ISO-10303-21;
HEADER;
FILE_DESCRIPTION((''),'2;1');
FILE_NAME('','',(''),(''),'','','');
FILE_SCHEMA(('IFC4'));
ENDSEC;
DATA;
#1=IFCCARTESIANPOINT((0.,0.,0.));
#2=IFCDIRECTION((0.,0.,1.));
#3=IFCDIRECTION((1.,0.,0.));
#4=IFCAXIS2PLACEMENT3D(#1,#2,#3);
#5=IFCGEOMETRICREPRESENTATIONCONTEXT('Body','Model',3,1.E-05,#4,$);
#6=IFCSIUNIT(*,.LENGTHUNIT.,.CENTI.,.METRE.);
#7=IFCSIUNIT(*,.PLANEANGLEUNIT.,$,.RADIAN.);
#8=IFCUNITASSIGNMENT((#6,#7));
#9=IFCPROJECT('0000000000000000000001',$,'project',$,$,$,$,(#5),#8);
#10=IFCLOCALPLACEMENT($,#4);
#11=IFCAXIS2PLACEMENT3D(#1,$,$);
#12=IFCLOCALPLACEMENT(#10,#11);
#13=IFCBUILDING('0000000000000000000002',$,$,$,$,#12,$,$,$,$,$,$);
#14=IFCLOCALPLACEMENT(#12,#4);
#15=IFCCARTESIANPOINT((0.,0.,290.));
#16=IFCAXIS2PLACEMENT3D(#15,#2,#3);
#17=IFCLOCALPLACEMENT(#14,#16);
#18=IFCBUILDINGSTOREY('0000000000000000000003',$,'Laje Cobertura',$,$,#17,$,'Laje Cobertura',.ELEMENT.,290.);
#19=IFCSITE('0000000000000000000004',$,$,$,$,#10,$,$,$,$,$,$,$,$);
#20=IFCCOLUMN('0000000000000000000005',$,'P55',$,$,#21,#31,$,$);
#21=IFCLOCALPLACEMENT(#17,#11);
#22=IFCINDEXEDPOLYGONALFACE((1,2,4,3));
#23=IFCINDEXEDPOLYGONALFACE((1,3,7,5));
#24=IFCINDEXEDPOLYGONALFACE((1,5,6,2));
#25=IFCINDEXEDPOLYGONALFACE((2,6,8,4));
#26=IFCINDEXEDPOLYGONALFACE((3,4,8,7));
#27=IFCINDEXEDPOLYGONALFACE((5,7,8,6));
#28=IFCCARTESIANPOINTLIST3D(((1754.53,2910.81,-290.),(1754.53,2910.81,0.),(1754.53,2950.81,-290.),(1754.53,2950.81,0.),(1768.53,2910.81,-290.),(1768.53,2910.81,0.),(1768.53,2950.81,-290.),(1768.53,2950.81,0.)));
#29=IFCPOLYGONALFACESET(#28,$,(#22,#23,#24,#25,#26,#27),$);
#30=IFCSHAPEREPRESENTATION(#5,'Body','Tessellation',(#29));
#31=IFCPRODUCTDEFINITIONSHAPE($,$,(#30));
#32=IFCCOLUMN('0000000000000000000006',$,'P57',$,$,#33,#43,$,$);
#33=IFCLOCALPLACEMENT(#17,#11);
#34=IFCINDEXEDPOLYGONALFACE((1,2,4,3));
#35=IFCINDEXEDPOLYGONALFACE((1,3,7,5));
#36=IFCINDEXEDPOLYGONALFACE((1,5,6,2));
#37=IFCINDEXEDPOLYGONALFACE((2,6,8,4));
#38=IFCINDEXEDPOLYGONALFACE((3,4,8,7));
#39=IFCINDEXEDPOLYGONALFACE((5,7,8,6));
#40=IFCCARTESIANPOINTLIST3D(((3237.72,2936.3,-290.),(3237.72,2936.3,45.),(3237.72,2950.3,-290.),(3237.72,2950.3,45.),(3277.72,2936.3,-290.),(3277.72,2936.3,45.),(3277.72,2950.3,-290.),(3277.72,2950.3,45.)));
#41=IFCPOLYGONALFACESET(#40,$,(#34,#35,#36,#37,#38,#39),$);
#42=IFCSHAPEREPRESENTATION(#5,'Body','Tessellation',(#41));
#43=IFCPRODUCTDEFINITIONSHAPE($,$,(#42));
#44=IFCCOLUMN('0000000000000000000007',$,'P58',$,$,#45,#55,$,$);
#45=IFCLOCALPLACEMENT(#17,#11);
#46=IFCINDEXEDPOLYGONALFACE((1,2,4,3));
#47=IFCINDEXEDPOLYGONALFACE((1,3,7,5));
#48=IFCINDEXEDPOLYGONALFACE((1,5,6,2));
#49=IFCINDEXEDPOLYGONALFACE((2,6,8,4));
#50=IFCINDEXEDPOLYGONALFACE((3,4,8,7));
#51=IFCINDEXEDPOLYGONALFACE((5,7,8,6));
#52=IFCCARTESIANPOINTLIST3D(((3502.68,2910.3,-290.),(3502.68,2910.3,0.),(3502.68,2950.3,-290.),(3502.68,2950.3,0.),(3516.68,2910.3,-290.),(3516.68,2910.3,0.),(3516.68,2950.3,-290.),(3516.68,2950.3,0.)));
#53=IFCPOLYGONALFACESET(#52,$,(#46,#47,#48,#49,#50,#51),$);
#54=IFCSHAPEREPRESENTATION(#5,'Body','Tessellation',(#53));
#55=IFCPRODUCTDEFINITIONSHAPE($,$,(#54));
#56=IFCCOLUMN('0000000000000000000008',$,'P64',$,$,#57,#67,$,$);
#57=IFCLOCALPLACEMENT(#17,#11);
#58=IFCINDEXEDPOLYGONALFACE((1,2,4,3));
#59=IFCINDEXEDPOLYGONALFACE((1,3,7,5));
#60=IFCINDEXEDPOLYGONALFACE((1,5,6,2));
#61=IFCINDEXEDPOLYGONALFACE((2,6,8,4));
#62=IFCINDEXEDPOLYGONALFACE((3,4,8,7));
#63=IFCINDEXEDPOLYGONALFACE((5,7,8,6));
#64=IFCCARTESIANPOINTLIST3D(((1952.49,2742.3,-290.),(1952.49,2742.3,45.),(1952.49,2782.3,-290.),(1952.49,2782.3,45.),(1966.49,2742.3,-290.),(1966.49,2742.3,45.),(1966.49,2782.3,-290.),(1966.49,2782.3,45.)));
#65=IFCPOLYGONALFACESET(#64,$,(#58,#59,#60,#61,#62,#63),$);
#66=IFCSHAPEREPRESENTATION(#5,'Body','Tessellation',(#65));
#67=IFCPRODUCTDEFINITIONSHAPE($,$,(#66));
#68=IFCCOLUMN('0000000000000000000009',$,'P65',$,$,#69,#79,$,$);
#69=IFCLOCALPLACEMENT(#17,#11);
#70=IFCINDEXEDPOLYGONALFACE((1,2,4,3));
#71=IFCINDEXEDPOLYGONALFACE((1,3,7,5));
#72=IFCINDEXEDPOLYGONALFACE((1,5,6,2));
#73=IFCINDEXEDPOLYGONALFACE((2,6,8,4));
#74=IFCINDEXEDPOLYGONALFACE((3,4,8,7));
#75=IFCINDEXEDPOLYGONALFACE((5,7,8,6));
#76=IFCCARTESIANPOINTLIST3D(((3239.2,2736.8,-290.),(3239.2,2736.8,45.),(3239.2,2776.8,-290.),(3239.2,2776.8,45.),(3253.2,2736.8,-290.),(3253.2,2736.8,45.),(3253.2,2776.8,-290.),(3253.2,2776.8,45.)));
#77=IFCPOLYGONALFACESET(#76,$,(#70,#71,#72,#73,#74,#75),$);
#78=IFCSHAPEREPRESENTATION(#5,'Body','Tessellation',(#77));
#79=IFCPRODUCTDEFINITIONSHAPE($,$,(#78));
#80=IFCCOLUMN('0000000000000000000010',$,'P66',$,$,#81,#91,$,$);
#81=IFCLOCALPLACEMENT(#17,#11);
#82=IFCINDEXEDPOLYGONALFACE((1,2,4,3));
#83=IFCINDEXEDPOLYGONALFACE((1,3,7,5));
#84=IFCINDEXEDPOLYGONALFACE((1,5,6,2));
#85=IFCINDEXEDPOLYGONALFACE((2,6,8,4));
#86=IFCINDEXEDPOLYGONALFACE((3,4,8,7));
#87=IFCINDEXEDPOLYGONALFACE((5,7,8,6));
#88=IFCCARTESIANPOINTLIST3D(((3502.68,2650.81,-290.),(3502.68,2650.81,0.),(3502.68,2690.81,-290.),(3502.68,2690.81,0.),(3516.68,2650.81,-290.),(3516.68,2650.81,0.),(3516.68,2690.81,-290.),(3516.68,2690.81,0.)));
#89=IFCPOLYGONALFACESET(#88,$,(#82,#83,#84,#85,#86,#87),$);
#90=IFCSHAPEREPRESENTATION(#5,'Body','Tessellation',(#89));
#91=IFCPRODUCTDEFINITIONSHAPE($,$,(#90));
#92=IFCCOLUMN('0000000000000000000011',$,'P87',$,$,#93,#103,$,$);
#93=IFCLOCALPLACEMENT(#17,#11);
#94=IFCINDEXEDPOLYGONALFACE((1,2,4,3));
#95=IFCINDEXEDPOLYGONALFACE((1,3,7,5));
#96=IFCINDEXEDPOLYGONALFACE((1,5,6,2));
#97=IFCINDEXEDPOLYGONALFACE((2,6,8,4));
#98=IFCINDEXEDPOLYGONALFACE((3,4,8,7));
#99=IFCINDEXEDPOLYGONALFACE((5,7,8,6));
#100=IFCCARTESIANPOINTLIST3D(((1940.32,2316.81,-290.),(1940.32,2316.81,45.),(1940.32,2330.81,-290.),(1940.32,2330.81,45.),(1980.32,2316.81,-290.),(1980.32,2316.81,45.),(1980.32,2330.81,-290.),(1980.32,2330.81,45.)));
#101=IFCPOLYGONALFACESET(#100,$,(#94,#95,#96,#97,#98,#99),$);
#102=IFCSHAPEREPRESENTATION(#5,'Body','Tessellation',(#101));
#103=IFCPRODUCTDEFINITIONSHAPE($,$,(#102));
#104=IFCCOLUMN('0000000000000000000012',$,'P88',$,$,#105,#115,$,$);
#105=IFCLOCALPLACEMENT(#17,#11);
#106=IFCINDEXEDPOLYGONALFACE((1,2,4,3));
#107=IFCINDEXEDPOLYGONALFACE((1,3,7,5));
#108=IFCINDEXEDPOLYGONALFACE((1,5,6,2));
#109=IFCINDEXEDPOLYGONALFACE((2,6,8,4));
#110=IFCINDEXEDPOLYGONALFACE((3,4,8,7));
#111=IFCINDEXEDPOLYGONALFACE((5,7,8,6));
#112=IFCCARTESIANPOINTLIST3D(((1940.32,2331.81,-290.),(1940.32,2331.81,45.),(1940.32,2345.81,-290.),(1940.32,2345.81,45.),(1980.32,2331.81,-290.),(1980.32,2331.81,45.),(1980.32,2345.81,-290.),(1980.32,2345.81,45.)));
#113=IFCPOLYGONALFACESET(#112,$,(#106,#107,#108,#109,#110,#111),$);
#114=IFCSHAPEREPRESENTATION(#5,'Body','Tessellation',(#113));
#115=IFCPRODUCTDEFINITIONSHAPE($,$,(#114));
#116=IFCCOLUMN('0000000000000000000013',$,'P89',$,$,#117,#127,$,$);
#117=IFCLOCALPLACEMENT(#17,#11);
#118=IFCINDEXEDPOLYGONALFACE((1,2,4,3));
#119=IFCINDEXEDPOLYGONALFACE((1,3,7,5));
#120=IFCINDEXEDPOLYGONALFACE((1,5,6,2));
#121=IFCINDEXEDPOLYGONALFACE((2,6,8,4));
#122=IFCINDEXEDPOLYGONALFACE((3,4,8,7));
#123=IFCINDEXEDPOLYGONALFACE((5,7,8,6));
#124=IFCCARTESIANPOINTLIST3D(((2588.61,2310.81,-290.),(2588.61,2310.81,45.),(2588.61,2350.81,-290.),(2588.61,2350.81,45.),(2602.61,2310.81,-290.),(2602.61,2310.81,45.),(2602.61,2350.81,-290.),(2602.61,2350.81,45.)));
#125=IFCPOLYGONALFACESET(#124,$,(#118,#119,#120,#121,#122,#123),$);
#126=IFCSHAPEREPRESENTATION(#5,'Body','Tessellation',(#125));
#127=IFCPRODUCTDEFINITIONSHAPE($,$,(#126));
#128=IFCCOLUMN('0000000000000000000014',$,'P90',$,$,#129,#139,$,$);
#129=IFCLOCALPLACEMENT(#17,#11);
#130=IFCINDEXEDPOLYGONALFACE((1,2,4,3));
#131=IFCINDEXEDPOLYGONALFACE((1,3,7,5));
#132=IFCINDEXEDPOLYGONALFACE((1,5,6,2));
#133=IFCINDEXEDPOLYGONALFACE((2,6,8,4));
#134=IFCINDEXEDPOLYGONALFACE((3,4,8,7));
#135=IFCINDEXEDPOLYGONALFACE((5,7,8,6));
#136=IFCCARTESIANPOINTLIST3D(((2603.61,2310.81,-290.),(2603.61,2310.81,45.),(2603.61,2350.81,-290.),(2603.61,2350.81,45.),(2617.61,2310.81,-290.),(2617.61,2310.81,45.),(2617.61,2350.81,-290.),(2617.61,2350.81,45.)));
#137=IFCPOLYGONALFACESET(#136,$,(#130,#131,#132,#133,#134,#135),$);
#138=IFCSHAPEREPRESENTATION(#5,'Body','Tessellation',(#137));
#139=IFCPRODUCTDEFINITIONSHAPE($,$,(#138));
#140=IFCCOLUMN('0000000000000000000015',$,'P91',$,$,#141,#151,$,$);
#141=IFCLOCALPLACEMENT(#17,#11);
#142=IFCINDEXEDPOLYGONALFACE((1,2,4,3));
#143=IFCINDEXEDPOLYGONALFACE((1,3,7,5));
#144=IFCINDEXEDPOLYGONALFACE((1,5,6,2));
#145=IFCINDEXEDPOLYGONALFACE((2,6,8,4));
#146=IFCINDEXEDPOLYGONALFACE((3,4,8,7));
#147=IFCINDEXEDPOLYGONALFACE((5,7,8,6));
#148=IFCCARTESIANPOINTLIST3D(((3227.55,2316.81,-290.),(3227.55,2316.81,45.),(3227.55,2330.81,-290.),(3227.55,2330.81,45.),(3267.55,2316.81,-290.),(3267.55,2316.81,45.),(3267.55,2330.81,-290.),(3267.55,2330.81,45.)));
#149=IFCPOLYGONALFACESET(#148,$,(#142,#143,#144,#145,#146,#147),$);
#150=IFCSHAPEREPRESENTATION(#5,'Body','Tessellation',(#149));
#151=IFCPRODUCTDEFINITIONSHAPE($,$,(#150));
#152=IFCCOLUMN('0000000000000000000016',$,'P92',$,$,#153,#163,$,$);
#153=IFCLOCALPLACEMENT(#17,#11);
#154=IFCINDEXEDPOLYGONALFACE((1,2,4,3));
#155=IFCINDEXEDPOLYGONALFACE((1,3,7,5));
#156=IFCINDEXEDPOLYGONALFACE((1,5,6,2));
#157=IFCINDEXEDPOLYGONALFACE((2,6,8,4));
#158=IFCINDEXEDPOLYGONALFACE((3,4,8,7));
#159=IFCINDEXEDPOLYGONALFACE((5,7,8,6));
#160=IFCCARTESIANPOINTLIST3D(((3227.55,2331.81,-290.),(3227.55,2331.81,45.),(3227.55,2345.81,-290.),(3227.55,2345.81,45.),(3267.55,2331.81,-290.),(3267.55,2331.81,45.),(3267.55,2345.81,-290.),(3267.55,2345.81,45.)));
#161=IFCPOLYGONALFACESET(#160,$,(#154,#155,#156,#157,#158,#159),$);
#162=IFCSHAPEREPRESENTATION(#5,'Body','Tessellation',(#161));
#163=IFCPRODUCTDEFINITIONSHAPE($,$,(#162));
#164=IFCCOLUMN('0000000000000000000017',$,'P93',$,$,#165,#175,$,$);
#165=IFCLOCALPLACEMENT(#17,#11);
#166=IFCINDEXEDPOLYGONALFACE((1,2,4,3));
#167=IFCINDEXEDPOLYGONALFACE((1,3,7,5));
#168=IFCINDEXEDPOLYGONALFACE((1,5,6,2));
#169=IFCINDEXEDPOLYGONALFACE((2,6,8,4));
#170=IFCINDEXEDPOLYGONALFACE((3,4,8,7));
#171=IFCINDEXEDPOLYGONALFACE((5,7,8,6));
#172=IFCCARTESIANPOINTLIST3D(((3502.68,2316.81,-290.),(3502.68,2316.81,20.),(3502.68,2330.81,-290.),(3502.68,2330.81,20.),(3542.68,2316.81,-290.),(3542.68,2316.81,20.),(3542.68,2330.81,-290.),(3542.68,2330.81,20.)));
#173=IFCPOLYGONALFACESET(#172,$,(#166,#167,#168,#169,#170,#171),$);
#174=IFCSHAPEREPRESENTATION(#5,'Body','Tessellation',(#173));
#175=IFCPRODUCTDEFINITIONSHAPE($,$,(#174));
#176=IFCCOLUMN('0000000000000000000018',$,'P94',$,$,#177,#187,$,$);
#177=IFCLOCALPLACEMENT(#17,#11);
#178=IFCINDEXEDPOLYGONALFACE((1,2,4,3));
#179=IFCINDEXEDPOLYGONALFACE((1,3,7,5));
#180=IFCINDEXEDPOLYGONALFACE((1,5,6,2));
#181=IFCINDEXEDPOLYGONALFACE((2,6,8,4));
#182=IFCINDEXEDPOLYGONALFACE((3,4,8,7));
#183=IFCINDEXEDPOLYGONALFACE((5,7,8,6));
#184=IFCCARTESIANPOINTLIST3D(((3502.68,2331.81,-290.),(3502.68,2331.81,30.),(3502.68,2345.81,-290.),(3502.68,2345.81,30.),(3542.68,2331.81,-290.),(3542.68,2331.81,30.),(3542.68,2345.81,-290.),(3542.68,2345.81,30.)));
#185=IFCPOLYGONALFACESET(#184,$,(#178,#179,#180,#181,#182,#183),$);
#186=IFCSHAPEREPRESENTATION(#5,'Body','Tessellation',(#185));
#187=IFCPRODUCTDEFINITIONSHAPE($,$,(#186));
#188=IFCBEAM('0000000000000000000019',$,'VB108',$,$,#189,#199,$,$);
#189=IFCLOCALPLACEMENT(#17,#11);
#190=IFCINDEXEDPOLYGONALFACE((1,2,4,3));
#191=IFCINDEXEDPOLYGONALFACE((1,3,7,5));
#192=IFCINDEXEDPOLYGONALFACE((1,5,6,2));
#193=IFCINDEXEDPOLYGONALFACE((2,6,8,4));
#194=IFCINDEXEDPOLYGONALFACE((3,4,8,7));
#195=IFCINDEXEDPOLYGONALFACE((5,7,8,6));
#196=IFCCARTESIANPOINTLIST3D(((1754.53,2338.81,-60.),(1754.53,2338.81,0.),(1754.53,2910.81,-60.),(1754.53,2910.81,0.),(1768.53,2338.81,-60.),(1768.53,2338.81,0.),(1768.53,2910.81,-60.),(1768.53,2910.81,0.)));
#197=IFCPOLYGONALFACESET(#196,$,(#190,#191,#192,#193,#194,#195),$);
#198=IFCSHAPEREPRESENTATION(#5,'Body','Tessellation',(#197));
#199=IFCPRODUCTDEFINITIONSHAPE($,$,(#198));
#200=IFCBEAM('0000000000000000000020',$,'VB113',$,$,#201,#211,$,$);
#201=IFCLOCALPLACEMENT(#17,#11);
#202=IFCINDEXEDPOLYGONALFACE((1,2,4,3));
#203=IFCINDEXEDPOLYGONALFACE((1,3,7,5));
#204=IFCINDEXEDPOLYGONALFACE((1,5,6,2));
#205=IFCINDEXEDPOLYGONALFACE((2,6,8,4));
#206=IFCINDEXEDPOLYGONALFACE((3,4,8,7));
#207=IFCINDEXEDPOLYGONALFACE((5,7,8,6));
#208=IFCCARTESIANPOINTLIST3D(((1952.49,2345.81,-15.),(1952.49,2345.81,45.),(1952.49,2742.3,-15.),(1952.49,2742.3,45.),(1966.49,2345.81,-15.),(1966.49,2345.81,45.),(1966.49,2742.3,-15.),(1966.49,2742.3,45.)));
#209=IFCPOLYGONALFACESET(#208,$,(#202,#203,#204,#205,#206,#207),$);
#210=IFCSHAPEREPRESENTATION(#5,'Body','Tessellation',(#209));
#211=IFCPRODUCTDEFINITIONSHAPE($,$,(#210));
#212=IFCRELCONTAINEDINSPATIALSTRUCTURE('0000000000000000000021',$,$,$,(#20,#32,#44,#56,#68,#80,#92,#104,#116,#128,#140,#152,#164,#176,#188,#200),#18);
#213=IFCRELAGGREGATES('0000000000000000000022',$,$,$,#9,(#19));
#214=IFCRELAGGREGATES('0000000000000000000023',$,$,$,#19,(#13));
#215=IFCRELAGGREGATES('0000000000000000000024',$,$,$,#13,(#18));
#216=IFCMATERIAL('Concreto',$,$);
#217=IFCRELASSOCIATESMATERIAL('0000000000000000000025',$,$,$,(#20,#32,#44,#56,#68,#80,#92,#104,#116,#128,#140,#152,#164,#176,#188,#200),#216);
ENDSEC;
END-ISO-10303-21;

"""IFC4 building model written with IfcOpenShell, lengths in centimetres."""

from ifc_helpers import new_model, si_unit, frame, origin, origin_with_axes, origin_2d_with_axis, place, context, project, spatial, rectangle, extrude, material, element, save


model = new_model("IFC4")

# Units and contexts
model_context = context("Model", 3, precision=1e-05, world=origin_with_axes(), identifier="Body")
ifc_project = project(units=[si_unit("LENGTHUNIT", "METRE", prefix="CENTI"), si_unit("PLANEANGLEUNIT", "RADIAN")], contexts=[model_context])

# Site, building, storey
site_placement = place(None, origin_with_axes())
site = spatial("IfcSite", under=ifc_project, at=site_placement)
building_placement = place(site_placement, origin())
building = spatial("IfcBuilding", under=site, at=building_placement)
placement = place(building_placement, origin_with_axes())
storey_placement = place(placement, frame((0.0, 0.0, 290.0), z_axis=(0.0, 0.0, 1.0), x_axis=(1.0, 0.0, 0.0)))
storey = spatial("IfcBuildingStorey", under=building, at=storey_placement, Name="Laje Cobertura", LongName="Laje Cobertura", CompositionType="ELEMENT", Elevation=290.0)

# Columns
ifc_material = material(Name="Concreto")
column_1_placement = place(storey_placement, frame((1761.53, 2930.81, 0.0), z_axis=(0.0, 0.0, 1.0), x_axis=(1.0, 0.0, 0.0)))
element("IfcColumn", 1, at=column_1_placement, inside=storey, material=ifc_material, Name="P55", context=model_context, shape_type="SolidModel", body=[
    extrude(rectangle(XDim=14.0, YDim=40.0, at=origin_2d_with_axis()), origin_with_axes(), (0.0, 0.0, -1.0), 290.0),
])
column_2_placement = place(storey_placement, frame((3257.72, 2943.3, 45.0), z_axis=(0.0, 0.0, 1.0), x_axis=(1.0, 0.0, 0.0)))
element("IfcColumn", 2, at=column_2_placement, inside=storey, material=ifc_material, Name="P57", context=model_context, shape_type="SolidModel", body=[
    extrude(rectangle(XDim=14.0, YDim=40.0, at=origin_2d_with_axis()), frame((0.0, 0.0, 0.0), z_axis=(0.0, 0.0, 1.0), x_axis=(0.0, -1.0, 0.0)), (0.0, 0.0, -1.0), 335.0),
])
column_3_placement = place(storey_placement, frame((3509.68, 2930.3, 0.0), z_axis=(0.0, 0.0, 1.0), x_axis=(1.0, 0.0, 0.0)))
element("IfcColumn", 3, at=column_3_placement, inside=storey, material=ifc_material, Name="P58", context=model_context, shape_type="SolidModel", body=[
    extrude(rectangle(XDim=14.0, YDim=40.0, at=origin_2d_with_axis()), origin_with_axes(), (0.0, 0.0, -1.0), 290.0),
])
for number, where, z_axis, x_axis, name in (
    (4, (1959.49, 2762.3, 45.0), (0.0, 0.0, 1.0), (1.0, 0.0, 0.0), "P64"),
    (5, (3246.2, 2756.8, 45.0), (0.0, 0.0, 1.0), (1.0, 0.0, 0.0), "P65"),
):
    element("IfcColumn", number, at=place(storey_placement, frame(where, z_axis=z_axis, x_axis=x_axis)), inside=storey, material=ifc_material, Name=name, context=model_context, shape_type="SolidModel", body=[
        extrude(rectangle(XDim=14.0, YDim=40.0, at=origin_2d_with_axis()), origin_with_axes(), (0.0, 0.0, -1.0), 335.0),
    ])
column_4_placement = place(storey_placement, frame((3509.68, 2670.81, 0.0), z_axis=(0.0, 0.0, 1.0), x_axis=(1.0, 0.0, 0.0)))
element("IfcColumn", 6, at=column_4_placement, inside=storey, material=ifc_material, Name="P66", context=model_context, shape_type="SolidModel", body=[
    extrude(rectangle(XDim=14.0, YDim=40.0, at=origin_2d_with_axis()), origin_with_axes(), (0.0, 0.0, -1.0), 290.0),
])
for number, where, z_axis, x_axis, name in (
    (7, (1960.32, 2323.81, 45.0), (0.0, 0.0, 1.0), (1.0, 0.0, 0.0), "P87"),
    (8, (1960.32, 2338.81, 45.0), (0.0, 0.0, 1.0), (1.0, 0.0, 0.0), "P88"),
):
    element("IfcColumn", number, at=place(storey_placement, frame(where, z_axis=z_axis, x_axis=x_axis)), inside=storey, material=ifc_material, Name=name, context=model_context, shape_type="SolidModel", body=[
        extrude(rectangle(XDim=14.0, YDim=40.0, at=origin_2d_with_axis()), frame((0.0, 0.0, 0.0), z_axis=(0.0, 0.0, 1.0), x_axis=(0.0, -1.0, 0.0)), (0.0, 0.0, -1.0), 335.0),
    ])
for number, where, z_axis, x_axis, name in (
    (9, (2595.61, 2330.81, 45.0), (0.0, 0.0, 1.0), (1.0, 0.0, 0.0), "P89"),
    (10, (2610.61, 2330.81, 45.0), (0.0, 0.0, 1.0), (1.0, 0.0, 0.0), "P90"),
):
    element("IfcColumn", number, at=place(storey_placement, frame(where, z_axis=z_axis, x_axis=x_axis)), inside=storey, material=ifc_material, Name=name, context=model_context, shape_type="SolidModel", body=[
        extrude(rectangle(XDim=14.0, YDim=40.0, at=origin_2d_with_axis()), origin_with_axes(), (0.0, 0.0, -1.0), 335.0),
    ])
for number, where, z_axis, x_axis, name in (
    (11, (3247.55, 2323.81, 45.0), (0.0, 0.0, 1.0), (1.0, 0.0, 0.0), "P91"),
    (12, (3247.55, 2338.81, 45.0), (0.0, 0.0, 1.0), (1.0, 0.0, 0.0), "P92"),
):
    element("IfcColumn", number, at=place(storey_placement, frame(where, z_axis=z_axis, x_axis=x_axis)), inside=storey, material=ifc_material, Name=name, context=model_context, shape_type="SolidModel", body=[
        extrude(rectangle(XDim=14.0, YDim=40.0, at=origin_2d_with_axis()), frame((0.0, 0.0, 0.0), z_axis=(0.0, 0.0, 1.0), x_axis=(0.0, -1.0, 0.0)), (0.0, 0.0, -1.0), 335.0),
    ])
column_5_placement = place(storey_placement, frame((3522.68, 2323.81, 20.0), z_axis=(0.0, 0.0, 1.0), x_axis=(1.0, 0.0, 0.0)))
element("IfcColumn", 13, at=column_5_placement, inside=storey, material=ifc_material, Name="P93", context=model_context, shape_type="SolidModel", body=[
    extrude(rectangle(XDim=14.0, YDim=40.0, at=origin_2d_with_axis()), frame((0.0, 0.0, 0.0), z_axis=(0.0, 0.0, 1.0), x_axis=(0.0, -1.0, 0.0)), (0.0, 0.0, -1.0), 310.0),
])
column_6_placement = place(storey_placement, frame((3522.68, 2338.81, 30.0), z_axis=(0.0, 0.0, 1.0), x_axis=(1.0, 0.0, 0.0)))
element("IfcColumn", 14, at=column_6_placement, inside=storey, material=ifc_material, Name="P94", context=model_context, shape_type="SolidModel", body=[
    extrude(rectangle(XDim=14.0, YDim=40.0, at=origin_2d_with_axis()), frame((0.0, 0.0, 0.0), z_axis=(0.0, 0.0, 1.0), x_axis=(0.0, -1.0, 0.0)), (0.0, 0.0, -1.0), 320.0),
])

# Beams
beam_1_placement = place(storey_placement, frame((1761.53, 2624.81, 0.0), z_axis=(0.0, 0.0, 1.0), x_axis=(1.0, 0.0, 0.0)))
element("IfcBeam", 15, at=beam_1_placement, inside=storey, material=ifc_material, Name="VB108", context=model_context, shape_type="SolidModel", body=[
    extrude(rectangle(XDim=14.0, YDim=60.0, at=origin_2d_with_axis()), frame((0.0, -286.0, -30.0), z_axis=(0.0, 1.0, 0.0), x_axis=(1.0, 0.0, 0.0)), (0.0, 0.0, 1.0), 572.0),
])
beam_2_placement = place(storey_placement, frame((1959.49, 2544.05, 45.0), z_axis=(0.0, 0.0, 1.0), x_axis=(1.0, 0.0, 0.0)))
element("IfcBeam", 16, at=beam_2_placement, inside=storey, material=ifc_material, Name="VB113", context=model_context, shape_type="SolidModel", body=[
    extrude(rectangle(XDim=14.0, YDim=60.0, at=origin_2d_with_axis()), frame((0.0, -198.25, -30.0), z_axis=(0.0, 1.0, 0.0), x_axis=(1.0, 0.0, 0.0)), (0.0, 0.0, 1.0), 396.49),
])

save(model, "model.ifc")
